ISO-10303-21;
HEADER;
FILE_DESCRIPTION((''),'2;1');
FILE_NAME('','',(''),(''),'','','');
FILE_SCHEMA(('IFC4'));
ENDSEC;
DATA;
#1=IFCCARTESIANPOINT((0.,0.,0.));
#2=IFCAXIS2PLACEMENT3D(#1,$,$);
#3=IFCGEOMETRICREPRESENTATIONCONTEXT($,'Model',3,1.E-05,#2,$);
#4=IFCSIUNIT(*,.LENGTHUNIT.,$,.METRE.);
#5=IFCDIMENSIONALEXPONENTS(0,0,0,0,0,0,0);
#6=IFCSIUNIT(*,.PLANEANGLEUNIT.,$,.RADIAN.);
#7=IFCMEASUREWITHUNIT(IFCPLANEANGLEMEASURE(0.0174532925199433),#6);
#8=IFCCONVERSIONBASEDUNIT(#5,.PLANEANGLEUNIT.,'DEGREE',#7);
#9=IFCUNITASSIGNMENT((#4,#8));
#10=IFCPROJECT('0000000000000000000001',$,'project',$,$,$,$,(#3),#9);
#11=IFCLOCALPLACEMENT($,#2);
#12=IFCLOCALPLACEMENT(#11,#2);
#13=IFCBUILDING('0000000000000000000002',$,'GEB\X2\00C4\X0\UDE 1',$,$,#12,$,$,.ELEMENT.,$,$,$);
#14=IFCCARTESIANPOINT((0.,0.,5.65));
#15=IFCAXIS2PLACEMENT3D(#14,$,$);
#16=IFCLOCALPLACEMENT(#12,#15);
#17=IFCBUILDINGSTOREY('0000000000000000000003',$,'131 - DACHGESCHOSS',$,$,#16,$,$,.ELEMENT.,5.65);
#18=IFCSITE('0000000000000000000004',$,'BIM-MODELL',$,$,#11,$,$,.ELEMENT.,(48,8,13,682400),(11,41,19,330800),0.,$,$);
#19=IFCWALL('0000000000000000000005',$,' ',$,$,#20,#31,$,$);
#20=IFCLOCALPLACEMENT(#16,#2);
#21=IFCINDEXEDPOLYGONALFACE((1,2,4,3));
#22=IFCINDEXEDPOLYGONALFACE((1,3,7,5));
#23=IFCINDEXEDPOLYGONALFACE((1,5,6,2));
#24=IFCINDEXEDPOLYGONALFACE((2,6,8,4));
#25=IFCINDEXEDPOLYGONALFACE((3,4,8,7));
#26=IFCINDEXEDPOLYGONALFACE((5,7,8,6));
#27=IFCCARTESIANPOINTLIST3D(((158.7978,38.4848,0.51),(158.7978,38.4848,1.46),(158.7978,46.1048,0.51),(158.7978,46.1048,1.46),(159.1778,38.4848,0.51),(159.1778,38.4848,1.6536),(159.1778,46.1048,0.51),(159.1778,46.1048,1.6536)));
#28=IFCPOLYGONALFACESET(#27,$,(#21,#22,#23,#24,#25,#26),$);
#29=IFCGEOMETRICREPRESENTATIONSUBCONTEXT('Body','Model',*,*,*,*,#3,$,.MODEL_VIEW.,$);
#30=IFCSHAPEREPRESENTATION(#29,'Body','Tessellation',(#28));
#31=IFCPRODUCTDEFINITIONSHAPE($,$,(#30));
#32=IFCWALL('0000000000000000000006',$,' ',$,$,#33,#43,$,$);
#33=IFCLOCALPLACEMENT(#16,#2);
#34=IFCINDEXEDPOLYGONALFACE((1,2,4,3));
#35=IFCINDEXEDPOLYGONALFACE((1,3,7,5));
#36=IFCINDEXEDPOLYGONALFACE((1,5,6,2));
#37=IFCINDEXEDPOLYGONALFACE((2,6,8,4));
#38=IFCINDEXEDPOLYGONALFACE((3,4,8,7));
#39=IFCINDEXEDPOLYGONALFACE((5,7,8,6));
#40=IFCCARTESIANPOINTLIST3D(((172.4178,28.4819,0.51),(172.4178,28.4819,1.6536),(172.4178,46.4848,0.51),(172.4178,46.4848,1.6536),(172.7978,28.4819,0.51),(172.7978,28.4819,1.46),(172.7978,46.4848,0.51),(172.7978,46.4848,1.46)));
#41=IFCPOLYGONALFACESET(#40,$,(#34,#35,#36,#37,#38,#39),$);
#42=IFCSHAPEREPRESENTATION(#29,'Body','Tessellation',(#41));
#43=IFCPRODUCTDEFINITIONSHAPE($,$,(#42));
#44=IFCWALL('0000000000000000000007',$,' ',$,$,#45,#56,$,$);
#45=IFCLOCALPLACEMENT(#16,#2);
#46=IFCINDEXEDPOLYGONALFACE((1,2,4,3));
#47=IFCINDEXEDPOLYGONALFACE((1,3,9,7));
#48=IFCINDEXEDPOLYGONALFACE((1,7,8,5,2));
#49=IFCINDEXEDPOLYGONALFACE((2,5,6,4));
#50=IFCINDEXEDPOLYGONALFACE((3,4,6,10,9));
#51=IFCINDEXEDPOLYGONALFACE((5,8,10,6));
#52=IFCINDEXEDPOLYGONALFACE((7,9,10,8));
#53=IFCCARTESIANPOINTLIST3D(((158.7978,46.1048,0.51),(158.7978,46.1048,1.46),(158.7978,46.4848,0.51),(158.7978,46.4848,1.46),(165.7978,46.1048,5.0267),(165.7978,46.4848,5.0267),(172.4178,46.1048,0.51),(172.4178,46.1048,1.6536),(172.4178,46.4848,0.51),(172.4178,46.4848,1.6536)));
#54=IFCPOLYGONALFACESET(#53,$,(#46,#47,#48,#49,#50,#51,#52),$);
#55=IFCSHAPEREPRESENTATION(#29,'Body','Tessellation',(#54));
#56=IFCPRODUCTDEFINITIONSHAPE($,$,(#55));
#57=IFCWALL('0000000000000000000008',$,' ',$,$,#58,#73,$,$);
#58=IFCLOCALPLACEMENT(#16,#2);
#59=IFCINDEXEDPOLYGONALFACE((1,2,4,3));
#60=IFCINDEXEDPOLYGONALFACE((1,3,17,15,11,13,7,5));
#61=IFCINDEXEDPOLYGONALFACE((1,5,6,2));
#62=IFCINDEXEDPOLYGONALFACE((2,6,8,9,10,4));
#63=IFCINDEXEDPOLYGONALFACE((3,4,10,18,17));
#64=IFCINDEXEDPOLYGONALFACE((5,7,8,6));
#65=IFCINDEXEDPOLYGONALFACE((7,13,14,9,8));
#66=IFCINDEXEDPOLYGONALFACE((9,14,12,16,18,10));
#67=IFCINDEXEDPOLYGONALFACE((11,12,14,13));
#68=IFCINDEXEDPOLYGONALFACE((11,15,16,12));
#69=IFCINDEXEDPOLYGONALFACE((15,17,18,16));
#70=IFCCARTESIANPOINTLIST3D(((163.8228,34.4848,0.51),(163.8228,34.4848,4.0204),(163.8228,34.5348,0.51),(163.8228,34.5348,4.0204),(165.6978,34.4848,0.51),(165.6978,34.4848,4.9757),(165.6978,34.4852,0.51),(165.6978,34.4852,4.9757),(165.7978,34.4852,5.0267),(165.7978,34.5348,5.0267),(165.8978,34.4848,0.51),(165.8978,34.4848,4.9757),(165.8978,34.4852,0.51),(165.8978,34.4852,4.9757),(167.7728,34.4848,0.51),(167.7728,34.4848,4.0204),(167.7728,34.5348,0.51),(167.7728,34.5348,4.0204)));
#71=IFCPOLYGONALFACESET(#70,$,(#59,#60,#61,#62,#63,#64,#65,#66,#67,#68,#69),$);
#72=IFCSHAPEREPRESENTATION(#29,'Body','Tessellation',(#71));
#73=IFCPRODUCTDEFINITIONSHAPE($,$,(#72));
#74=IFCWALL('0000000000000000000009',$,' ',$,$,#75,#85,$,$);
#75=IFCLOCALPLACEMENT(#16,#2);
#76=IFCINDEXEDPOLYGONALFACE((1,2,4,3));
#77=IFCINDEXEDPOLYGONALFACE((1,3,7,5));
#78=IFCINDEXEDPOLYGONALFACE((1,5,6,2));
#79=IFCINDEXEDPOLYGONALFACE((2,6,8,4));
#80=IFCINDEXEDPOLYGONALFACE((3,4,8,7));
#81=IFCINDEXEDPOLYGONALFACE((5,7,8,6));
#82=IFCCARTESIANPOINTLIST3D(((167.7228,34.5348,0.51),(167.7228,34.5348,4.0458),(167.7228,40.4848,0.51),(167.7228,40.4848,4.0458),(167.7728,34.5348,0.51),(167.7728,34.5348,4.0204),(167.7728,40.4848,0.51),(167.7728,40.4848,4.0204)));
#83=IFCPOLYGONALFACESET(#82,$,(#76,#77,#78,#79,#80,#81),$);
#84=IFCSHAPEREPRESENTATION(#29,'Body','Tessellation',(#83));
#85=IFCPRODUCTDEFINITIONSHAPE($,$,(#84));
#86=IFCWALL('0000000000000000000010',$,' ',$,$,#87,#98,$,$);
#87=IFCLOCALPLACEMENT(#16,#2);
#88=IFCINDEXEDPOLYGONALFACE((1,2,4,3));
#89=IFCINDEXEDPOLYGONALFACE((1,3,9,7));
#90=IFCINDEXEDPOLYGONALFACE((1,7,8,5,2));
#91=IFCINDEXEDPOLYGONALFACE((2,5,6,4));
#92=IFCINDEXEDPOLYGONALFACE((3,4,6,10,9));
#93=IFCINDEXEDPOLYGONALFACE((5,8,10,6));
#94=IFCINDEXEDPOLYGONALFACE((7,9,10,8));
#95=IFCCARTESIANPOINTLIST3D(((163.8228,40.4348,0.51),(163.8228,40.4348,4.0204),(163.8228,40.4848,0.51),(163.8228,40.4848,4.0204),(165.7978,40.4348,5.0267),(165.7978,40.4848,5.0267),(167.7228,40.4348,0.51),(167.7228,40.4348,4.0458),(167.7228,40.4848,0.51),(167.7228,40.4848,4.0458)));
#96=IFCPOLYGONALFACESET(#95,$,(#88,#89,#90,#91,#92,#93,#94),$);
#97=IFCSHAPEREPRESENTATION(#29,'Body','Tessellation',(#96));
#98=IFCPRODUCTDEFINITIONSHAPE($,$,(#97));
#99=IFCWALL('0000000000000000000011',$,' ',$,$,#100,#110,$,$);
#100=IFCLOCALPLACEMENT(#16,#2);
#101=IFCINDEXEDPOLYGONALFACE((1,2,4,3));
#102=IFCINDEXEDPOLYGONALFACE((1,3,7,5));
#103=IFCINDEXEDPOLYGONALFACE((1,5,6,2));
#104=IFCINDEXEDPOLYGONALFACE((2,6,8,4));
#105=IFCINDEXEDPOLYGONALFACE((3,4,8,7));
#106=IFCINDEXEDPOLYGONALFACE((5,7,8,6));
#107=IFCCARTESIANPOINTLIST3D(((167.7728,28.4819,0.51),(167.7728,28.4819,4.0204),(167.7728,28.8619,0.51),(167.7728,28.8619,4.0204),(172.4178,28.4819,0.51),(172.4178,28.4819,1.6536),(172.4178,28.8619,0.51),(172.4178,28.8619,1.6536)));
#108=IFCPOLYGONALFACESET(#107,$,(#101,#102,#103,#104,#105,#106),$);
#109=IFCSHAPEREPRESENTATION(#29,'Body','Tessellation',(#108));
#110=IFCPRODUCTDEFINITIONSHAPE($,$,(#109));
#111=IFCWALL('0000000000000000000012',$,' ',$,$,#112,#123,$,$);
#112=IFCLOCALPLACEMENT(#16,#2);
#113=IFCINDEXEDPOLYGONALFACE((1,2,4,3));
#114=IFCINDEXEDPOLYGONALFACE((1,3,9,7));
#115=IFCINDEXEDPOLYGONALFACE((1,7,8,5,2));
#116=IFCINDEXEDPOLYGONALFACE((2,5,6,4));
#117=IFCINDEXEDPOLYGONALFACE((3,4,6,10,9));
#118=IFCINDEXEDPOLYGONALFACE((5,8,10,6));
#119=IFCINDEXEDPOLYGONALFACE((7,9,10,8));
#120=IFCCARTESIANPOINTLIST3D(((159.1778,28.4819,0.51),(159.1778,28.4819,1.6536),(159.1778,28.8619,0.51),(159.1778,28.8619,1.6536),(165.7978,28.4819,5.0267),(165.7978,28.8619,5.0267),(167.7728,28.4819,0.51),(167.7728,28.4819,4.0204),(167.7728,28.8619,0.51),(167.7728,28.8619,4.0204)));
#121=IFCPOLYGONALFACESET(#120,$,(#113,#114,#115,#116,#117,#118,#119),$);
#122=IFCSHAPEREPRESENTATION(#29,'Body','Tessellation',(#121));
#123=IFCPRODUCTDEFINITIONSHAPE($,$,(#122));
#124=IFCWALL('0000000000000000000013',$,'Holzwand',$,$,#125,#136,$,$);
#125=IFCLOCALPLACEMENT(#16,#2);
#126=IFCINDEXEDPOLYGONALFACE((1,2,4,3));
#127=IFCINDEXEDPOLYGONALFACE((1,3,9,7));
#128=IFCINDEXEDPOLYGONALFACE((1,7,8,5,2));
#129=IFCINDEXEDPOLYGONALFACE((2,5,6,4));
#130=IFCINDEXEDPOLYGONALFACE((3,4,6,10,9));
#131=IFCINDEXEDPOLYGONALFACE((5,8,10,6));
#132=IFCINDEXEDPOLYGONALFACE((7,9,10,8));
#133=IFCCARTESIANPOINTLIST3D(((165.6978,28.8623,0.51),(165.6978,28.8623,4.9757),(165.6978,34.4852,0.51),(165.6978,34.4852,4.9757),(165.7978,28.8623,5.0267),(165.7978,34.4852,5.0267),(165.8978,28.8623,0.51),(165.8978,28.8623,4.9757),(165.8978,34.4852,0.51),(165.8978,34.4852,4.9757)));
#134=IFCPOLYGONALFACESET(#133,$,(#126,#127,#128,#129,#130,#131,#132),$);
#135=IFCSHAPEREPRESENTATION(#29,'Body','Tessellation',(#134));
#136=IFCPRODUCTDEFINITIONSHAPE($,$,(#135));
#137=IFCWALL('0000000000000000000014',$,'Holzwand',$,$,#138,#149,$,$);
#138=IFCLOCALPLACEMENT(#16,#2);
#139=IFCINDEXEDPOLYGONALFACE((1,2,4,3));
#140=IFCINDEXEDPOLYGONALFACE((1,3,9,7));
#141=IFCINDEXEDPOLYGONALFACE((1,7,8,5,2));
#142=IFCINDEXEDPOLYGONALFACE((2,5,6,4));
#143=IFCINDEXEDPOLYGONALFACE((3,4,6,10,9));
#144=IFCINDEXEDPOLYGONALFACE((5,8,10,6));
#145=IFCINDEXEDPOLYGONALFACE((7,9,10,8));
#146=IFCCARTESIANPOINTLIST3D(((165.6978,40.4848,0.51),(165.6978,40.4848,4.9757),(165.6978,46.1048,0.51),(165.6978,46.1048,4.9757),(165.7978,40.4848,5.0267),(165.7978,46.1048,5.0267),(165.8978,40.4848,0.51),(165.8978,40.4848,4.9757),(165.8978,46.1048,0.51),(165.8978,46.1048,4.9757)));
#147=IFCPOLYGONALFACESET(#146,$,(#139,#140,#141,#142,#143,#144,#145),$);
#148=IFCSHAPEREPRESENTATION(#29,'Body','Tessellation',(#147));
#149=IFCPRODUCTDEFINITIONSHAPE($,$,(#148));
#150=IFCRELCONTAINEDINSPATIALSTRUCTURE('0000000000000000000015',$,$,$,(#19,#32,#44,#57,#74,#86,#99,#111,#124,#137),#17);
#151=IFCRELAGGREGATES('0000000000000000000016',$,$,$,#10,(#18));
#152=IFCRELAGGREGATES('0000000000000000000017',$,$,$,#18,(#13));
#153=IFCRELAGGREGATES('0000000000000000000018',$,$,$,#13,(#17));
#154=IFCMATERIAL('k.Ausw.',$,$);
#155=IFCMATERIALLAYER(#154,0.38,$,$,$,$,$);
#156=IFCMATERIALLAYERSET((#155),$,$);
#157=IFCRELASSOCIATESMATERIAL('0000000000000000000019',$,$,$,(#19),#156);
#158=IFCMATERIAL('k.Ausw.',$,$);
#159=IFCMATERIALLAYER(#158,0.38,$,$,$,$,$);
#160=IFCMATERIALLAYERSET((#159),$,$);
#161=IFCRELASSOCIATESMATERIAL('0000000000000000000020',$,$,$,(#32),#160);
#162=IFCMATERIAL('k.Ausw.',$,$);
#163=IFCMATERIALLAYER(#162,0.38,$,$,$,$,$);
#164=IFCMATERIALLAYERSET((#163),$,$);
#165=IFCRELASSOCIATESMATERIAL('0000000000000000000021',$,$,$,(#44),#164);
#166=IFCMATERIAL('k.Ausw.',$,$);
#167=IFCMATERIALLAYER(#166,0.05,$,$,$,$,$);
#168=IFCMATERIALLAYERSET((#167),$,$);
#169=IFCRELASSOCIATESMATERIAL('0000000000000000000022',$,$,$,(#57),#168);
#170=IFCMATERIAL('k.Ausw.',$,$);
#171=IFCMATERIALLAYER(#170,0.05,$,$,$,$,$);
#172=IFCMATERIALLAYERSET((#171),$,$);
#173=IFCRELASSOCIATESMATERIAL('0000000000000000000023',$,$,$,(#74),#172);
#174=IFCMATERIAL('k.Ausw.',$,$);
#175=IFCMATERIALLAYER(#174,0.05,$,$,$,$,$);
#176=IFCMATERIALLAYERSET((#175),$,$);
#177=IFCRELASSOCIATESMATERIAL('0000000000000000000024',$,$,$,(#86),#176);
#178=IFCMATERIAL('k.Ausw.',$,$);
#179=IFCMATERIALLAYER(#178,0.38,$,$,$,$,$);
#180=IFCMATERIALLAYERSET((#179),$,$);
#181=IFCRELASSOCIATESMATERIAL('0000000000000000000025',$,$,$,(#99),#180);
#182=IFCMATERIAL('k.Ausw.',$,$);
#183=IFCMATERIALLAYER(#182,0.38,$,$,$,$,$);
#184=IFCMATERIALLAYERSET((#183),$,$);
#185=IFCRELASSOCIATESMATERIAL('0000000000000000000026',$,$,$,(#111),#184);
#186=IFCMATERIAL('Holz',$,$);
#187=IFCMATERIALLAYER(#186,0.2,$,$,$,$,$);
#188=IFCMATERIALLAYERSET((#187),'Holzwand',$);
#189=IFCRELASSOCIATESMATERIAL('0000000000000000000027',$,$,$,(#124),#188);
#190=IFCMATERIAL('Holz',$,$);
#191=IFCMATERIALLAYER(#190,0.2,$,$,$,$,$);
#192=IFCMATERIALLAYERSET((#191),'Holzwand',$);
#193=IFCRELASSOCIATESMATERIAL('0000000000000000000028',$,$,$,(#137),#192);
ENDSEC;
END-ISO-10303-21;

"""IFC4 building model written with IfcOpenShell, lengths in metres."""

from ifc_helpers import new_model, entity, si_unit, converted_unit, frame, frame_2d, origin, origin_with_axes, place, context, subcontext, project, spatial, polyline, rectangle, outline, extrude, clip, halfspace, bounded_halfspace, material, layer, layer_set, layer_usage, element, save


model = new_model("IFC4")

# Units and contexts
model_context = context("Model", 3, precision=1e-05, world=origin())
body_context = subcontext(model_context, "Body", "Model", "MODEL_VIEW")
ifc_project = project(units=[si_unit("LENGTHUNIT", "METRE"), converted_unit("PLANEANGLEUNIT", "DEGREE", entity("IfcPlaneAngleMeasure", 0.0174532925199433), si_unit("PLANEANGLEUNIT", "RADIAN"), dimensions=[0, 0, 0, 0, 0, 0, 0])], contexts=[model_context])

# Site, building, storey
site_placement = place(None, origin())
site = spatial("IfcSite", under=ifc_project, at=site_placement, Name="BIM-MODELL", CompositionType="ELEMENT", RefLatitude=(48, 8, 13, 682400), RefLongitude=(11, 41, 19, 330800), RefElevation=0.0)
building_placement = place(site_placement, origin())
building = spatial("IfcBuilding", under=site, at=building_placement, Name="GEBÄUDE 1", CompositionType="ELEMENT")
storey_placement = place(building_placement, frame((0.0, 0.0, 5.65)))
storey = spatial("IfcBuildingStorey", under=building, at=storey_placement, Name="131 - DACHGESCHOSS", CompositionType="ELEMENT", Elevation=5.65)

# Walls
ifc_material_1 = material(Name="k.Ausw.")
ifc_layer_1 = layer(ifc_material_1, 0.38)
ifc_layer_set_1 = layer_set([ifc_layer_1])
ifc_layer_usage_1 = layer_usage(ifc_layer_set_1, "AXIS2", "POSITIVE", 0.0)
wall_1_placement = place(storey_placement, frame((158.7978, 46.1048, 0.51), z_axis=(0.0, 0.0, 1.0), x_axis=(0.0, -1.0, 0.0)))
element("IfcWall", 1, at=wall_1_placement, inside=storey, material=ifc_layer_usage_1, Name=" ", context=body_context, shape_type="Clipping", body=[
    clip(extrude(rectangle(XDim=7.62, YDim=0.38, at=frame_2d((3.81, 0.19), x_axis=(1.0, 0.0))), origin_with_axes(), (0.0, 0.0, 1.0), 1.1436), halfspace(frame((3.81, 0.19, 1.0468), z_axis=(0.0, 0.45399, -0.891007), x_axis=(0.0, -0.891007, -0.45399)), True)),
])
ifc_material_2 = material(Name="k.Ausw.")
ifc_layer_2 = layer(ifc_material_2, 0.38)
ifc_layer_set_2 = layer_set([ifc_layer_2])
ifc_layer_usage_2 = layer_usage(ifc_layer_set_2, "AXIS2", "POSITIVE", 0.0)
wall_2_placement = place(storey_placement, frame((172.7978, 28.4819, 0.51), z_axis=(0.0, 0.0, 1.0), x_axis=(0.0, 1.0, 0.0)))
element("IfcWall", 2, at=wall_2_placement, inside=storey, material=ifc_layer_usage_2, Name=" ", context=body_context, shape_type="Clipping", body=[
    clip(extrude(rectangle(XDim=18.0029, YDim=0.38, at=frame_2d((9.0014, 0.19), x_axis=(1.0, 0.0))), origin_with_axes(), (0.0, 0.0, 1.0), 1.1436), halfspace(frame((9.0014, 0.19, 1.0468), z_axis=(0.0, 0.45399, -0.891007), x_axis=(0.0, -0.891007, -0.45399)), True)),
])
ifc_material_3 = material(Name="k.Ausw.")
ifc_layer_3 = layer(ifc_material_3, 0.38)
ifc_layer_set_3 = layer_set([ifc_layer_3])
ifc_layer_usage_3 = layer_usage(ifc_layer_set_3, "AXIS2", "POSITIVE", 0.0)
wall_3_placement = place(storey_placement, frame((172.4178, 46.4848, 0.51), z_axis=(0.0, 0.0, 1.0), x_axis=(-1.0, 0.0, 0.0)))
element("IfcWall", 3, at=wall_3_placement, inside=storey, material=ifc_layer_usage_3, Name=" ", context=body_context, shape_type="Clipping", body=[
    clip(clip(extrude(rectangle(XDim=13.62, YDim=0.38, at=frame_2d((6.81, 0.19), x_axis=(1.0, 0.0))), origin_with_axes(), (0.0, 0.0, 1.0), 4.5167), bounded_halfspace(frame((3.31, 0.19, 2.8301), z_axis=(0.45399, 0.0, -0.891007), x_axis=(0.0, -1.0, 0.0)), True, origin_with_axes(), polyline([(0.0, 0.38), (0.0, 0.0), (6.62, 0.0), (6.62, 0.38), (0.0, 0.38)]))), bounded_halfspace(frame((10.12, 0.19, 2.7333), z_axis=(-0.45399, 0.0, -0.891007), x_axis=(0.891007, 0.0, -0.45399)), True, origin_with_axes(), polyline([(6.62, 0.0), (13.62, 0.0), (13.62, 0.38), (6.62, 0.38), (6.62, 0.0)]))),
])
ifc_material_4 = material(Name="k.Ausw.")
ifc_layer_4 = layer(ifc_material_4, 0.05)
ifc_layer_set_4 = layer_set([ifc_layer_4])
ifc_layer_usage_4 = layer_usage(ifc_layer_set_4, "AXIS2", "POSITIVE", 0.0)
wall_4_placement = place(storey_placement, frame((163.8228, 34.4848, 0.51), z_axis=(0.0, 0.0, 1.0), x_axis=(1.0, 0.0, 0.0)))
element("IfcWall", 4, at=wall_4_placement, inside=storey, material=ifc_layer_usage_4, Name=" ", context=body_context, shape_type="Clipping", body=[
    clip(clip(extrude(outline(polyline([(0.0, 0.0), (1.875, 0.0), (1.875, 0.0004), (2.075, 0.0004), (2.075, 0.0), (3.95, 0.0), (3.95, 0.05), (0.0, 0.05), (0.0, 0.0)])), origin_with_axes(), (0.0, 0.0, 1.0), 4.5167), bounded_halfspace(frame((2.6667, 0.0168, 4.1643), z_axis=(-0.45399, 0.0, -0.891007), x_axis=(-0.891007, 0.0, 0.45399)), True, origin_with_axes(), polyline([(3.95, 0.05), (1.975, 0.05), (1.975, 0.0004), (2.075, 0.0004), (2.075, 0.0), (3.95, 0.0), (3.95, 0.05)]))), bounded_halfspace(frame((1.2833, 0.0168, 4.1643), z_axis=(0.45399, 0.0, -0.891007), x_axis=(0.891007, 0.0, 0.45399)), True, origin_with_axes(), polyline([(0.0, 0.0), (1.875, 0.0), (1.875, 0.0004), (1.975, 0.0004), (1.975, 0.05), (0.0, 0.05), (0.0, 0.0)]))),
])
ifc_material_5 = material(Name="k.Ausw.")
ifc_layer_5 = layer(ifc_material_5, 0.05)
ifc_layer_set_5 = layer_set([ifc_layer_5])
ifc_layer_usage_5 = layer_usage(ifc_layer_set_5, "AXIS2", "POSITIVE", 0.0)
wall_5_placement = place(storey_placement, frame((167.7728, 34.5348, 0.51), z_axis=(0.0, 0.0, 1.0), x_axis=(0.0, 1.0, 0.0)))
element("IfcWall", 5, at=wall_5_placement, inside=storey, material=ifc_layer_usage_5, Name=" ", context=body_context, shape_type="Clipping", body=[
    clip(extrude(rectangle(XDim=5.95, YDim=0.05, at=frame_2d((2.975, 0.025), x_axis=(1.0, 0.0))), origin_with_axes(), (0.0, 0.0, 1.0), 3.5358), halfspace(frame((2.975, 0.025, 3.5231), z_axis=(0.0, 0.45399, -0.891007), x_axis=(1.0, 0.0, 0.0)), True)),
])
ifc_material_6 = material(Name="k.Ausw.")
ifc_layer_6 = layer(ifc_material_6, 0.05)
ifc_layer_set_6 = layer_set([ifc_layer_6])
ifc_layer_usage_6 = layer_usage(ifc_layer_set_6, "AXIS2", "POSITIVE", 0.0)
wall_6_placement = place(storey_placement, frame((167.7228, 40.4848, 0.51), z_axis=(0.0, 0.0, 1.0), x_axis=(-1.0, 0.0, 0.0)))
element("IfcWall", 6, at=wall_6_placement, inside=storey, material=ifc_layer_usage_6, Name=" ", context=body_context, shape_type="Clipping", body=[
    clip(clip(extrude(rectangle(XDim=3.9, YDim=0.05, at=frame_2d((1.95, 0.025), x_axis=(1.0, 0.0))), origin_with_axes(), (0.0, 0.0, 1.0), 4.5167), bounded_halfspace(frame((0.9625, 0.025, 4.0263), z_axis=(0.45399, 0.0, -0.891007), x_axis=(0.891007, 0.0, 0.45399)), True, origin_with_axes(), polyline([(0.0, 0.0), (1.925, 0.0), (1.925, 0.05), (0.0, 0.05), (0.0, 0.0)]))), bounded_halfspace(frame((2.9125, 0.025, 4.0135), z_axis=(-0.45399, 0.0, -0.891007), x_axis=(-0.891007, 0.0, 0.45399)), True, origin_with_axes(), polyline([(3.9, 0.05), (1.925, 0.05), (1.925, 0.0), (3.9, 0.0), (3.9, 0.05)]))),
])
ifc_material_7 = material(Name="k.Ausw.")
ifc_layer_7 = layer(ifc_material_7, 0.38)
ifc_layer_set_7 = layer_set([ifc_layer_7])
ifc_layer_usage_7 = layer_usage(ifc_layer_set_7, "AXIS2", "POSITIVE", 0.0)
wall_7_placement = place(storey_placement, frame((167.7728, 28.4819, 0.51), z_axis=(0.0, 0.0, 1.0), x_axis=(1.0, 0.0, 0.0)))
element("IfcWall", 7, at=wall_7_placement, inside=storey, material=ifc_layer_usage_7, Name=" ", context=body_context, shape_type="Clipping", body=[
    clip(extrude(rectangle(XDim=4.645, YDim=0.38, at=frame_2d((2.3225, 0.19), x_axis=(1.0, 0.0))), origin_with_axes(), (0.0, 0.0, 1.0), 3.5104), halfspace(frame((2.3225, 0.19, 2.327), z_axis=(-0.45399, 0.0, -0.891007), x_axis=(0.0, -1.0, 0.0)), True)),
])
ifc_material_8 = material(Name="k.Ausw.")
ifc_layer_8 = layer(ifc_material_8, 0.38)
ifc_layer_set_8 = layer_set([ifc_layer_8])
ifc_layer_usage_8 = layer_usage(ifc_layer_set_8, "AXIS2", "POSITIVE", 0.0)
wall_8_placement = place(storey_placement, frame((159.1778, 28.4819, 0.51), z_axis=(0.0, 0.0, 1.0), x_axis=(1.0, 0.0, 0.0)))
element("IfcWall", 8, at=wall_8_placement, inside=storey, material=ifc_layer_usage_8, Name=" ", context=body_context, shape_type="Clipping", body=[
    clip(clip(extrude(rectangle(XDim=8.595, YDim=0.38, at=frame_2d((4.2975, 0.19), x_axis=(1.0, 0.0))), origin_with_axes(), (0.0, 0.0, 1.0), 4.5167), bounded_halfspace(frame((7.6075, 0.19, 4.0135), z_axis=(-0.45399, 0.0, -0.891007), x_axis=(-0.891007, 0.0, 0.45399)), True, origin_with_axes(), polyline([(8.595, 0.38), (6.62, 0.38), (6.62, 0.0), (8.595, 0.0), (8.595, 0.38)]))), bounded_halfspace(frame((3.31, 0.19, 2.8301), z_axis=(0.45399, 0.0, -0.891007), x_axis=(0.0, -1.0, 0.0)), True, origin_with_axes(), polyline([(0.0, 0.38), (0.0, 0.0), (6.62, 0.0), (6.62, 0.38), (0.0, 0.38)]))),
])
ifc_material_9 = material(Name="Holz")
ifc_layer_9 = layer(ifc_material_9, 0.2)
ifc_layer_set_9 = layer_set([ifc_layer_9], Name="Holzwand")
ifc_layer_usage_9 = layer_usage(ifc_layer_set_9, "AXIS2", "POSITIVE", 0.0)
wall_9_placement = place(storey_placement, frame((165.6978, 34.4852, 0.51), z_axis=(0.0, 0.0, 1.0), x_axis=(0.0, -1.0, 0.0)))
element("IfcWall", 9, at=wall_9_placement, inside=storey, material=ifc_layer_usage_9, Name="Holzwand", context=body_context, shape_type="Clipping", body=[
    clip(clip(extrude(rectangle(XDim=5.6229, YDim=0.2, at=frame_2d((2.8114, 0.1), x_axis=(1.0, 0.0))), origin_with_axes(), (0.0, 0.0, 1.0), 4.5167), bounded_halfspace(frame((2.8114, 0.15, 4.4912), z_axis=(0.0, -0.45399, -0.891007), x_axis=(0.0, -0.891007, 0.45399)), True, origin_with_axes(), polyline([(0.0, 0.2), (0.0, 0.1), (5.6229, 0.1), (5.6229, 0.2), (0.0, 0.2)]))), bounded_halfspace(frame((2.8114, 0.05, 4.4912), z_axis=(0.0, 0.45399, -0.891007), x_axis=(1.0, 0.0, 0.0)), True, origin_with_axes(), polyline([(0.0, 0.0), (5.6229, 0.0), (5.6229, 0.1), (0.0, 0.1), (0.0, 0.0)]))),
])
ifc_material_10 = material(Name="Holz")
ifc_layer_10 = layer(ifc_material_10, 0.2)
ifc_layer_set_10 = layer_set([ifc_layer_10], Name="Holzwand")
ifc_layer_usage_10 = layer_usage(ifc_layer_set_10, "AXIS2", "POSITIVE", 0.0)
wall_10_placement = place(storey_placement, frame((165.6978, 46.1048, 0.51), z_axis=(0.0, 0.0, 1.0), x_axis=(0.0, -1.0, 0.0)))
element("IfcWall", 10, at=wall_10_placement, inside=storey, material=ifc_layer_usage_10, Name="Holzwand", context=body_context, shape_type="Clipping", body=[
    clip(clip(extrude(rectangle(XDim=5.62, YDim=0.2, at=frame_2d((2.81, 0.1), x_axis=(1.0, 0.0))), origin_with_axes(), (0.0, 0.0, 1.0), 4.5167), bounded_halfspace(frame((2.81, 0.15, 4.4912), z_axis=(0.0, -0.45399, -0.891007), x_axis=(0.0, -0.891007, 0.45399)), True, origin_with_axes(), polyline([(0.0, 0.2), (0.0, 0.1), (5.62, 0.1), (5.62, 0.2), (0.0, 0.2)]))), bounded_halfspace(frame((2.81, 0.05, 4.4912), z_axis=(0.0, 0.45399, -0.891007), x_axis=(1.0, 0.0, 0.0)), True, origin_with_axes(), polyline([(0.0, 0.0), (5.62, 0.0), (5.62, 0.1), (0.0, 0.1), (0.0, 0.0)]))),
])

save(model, "model.ifc")
